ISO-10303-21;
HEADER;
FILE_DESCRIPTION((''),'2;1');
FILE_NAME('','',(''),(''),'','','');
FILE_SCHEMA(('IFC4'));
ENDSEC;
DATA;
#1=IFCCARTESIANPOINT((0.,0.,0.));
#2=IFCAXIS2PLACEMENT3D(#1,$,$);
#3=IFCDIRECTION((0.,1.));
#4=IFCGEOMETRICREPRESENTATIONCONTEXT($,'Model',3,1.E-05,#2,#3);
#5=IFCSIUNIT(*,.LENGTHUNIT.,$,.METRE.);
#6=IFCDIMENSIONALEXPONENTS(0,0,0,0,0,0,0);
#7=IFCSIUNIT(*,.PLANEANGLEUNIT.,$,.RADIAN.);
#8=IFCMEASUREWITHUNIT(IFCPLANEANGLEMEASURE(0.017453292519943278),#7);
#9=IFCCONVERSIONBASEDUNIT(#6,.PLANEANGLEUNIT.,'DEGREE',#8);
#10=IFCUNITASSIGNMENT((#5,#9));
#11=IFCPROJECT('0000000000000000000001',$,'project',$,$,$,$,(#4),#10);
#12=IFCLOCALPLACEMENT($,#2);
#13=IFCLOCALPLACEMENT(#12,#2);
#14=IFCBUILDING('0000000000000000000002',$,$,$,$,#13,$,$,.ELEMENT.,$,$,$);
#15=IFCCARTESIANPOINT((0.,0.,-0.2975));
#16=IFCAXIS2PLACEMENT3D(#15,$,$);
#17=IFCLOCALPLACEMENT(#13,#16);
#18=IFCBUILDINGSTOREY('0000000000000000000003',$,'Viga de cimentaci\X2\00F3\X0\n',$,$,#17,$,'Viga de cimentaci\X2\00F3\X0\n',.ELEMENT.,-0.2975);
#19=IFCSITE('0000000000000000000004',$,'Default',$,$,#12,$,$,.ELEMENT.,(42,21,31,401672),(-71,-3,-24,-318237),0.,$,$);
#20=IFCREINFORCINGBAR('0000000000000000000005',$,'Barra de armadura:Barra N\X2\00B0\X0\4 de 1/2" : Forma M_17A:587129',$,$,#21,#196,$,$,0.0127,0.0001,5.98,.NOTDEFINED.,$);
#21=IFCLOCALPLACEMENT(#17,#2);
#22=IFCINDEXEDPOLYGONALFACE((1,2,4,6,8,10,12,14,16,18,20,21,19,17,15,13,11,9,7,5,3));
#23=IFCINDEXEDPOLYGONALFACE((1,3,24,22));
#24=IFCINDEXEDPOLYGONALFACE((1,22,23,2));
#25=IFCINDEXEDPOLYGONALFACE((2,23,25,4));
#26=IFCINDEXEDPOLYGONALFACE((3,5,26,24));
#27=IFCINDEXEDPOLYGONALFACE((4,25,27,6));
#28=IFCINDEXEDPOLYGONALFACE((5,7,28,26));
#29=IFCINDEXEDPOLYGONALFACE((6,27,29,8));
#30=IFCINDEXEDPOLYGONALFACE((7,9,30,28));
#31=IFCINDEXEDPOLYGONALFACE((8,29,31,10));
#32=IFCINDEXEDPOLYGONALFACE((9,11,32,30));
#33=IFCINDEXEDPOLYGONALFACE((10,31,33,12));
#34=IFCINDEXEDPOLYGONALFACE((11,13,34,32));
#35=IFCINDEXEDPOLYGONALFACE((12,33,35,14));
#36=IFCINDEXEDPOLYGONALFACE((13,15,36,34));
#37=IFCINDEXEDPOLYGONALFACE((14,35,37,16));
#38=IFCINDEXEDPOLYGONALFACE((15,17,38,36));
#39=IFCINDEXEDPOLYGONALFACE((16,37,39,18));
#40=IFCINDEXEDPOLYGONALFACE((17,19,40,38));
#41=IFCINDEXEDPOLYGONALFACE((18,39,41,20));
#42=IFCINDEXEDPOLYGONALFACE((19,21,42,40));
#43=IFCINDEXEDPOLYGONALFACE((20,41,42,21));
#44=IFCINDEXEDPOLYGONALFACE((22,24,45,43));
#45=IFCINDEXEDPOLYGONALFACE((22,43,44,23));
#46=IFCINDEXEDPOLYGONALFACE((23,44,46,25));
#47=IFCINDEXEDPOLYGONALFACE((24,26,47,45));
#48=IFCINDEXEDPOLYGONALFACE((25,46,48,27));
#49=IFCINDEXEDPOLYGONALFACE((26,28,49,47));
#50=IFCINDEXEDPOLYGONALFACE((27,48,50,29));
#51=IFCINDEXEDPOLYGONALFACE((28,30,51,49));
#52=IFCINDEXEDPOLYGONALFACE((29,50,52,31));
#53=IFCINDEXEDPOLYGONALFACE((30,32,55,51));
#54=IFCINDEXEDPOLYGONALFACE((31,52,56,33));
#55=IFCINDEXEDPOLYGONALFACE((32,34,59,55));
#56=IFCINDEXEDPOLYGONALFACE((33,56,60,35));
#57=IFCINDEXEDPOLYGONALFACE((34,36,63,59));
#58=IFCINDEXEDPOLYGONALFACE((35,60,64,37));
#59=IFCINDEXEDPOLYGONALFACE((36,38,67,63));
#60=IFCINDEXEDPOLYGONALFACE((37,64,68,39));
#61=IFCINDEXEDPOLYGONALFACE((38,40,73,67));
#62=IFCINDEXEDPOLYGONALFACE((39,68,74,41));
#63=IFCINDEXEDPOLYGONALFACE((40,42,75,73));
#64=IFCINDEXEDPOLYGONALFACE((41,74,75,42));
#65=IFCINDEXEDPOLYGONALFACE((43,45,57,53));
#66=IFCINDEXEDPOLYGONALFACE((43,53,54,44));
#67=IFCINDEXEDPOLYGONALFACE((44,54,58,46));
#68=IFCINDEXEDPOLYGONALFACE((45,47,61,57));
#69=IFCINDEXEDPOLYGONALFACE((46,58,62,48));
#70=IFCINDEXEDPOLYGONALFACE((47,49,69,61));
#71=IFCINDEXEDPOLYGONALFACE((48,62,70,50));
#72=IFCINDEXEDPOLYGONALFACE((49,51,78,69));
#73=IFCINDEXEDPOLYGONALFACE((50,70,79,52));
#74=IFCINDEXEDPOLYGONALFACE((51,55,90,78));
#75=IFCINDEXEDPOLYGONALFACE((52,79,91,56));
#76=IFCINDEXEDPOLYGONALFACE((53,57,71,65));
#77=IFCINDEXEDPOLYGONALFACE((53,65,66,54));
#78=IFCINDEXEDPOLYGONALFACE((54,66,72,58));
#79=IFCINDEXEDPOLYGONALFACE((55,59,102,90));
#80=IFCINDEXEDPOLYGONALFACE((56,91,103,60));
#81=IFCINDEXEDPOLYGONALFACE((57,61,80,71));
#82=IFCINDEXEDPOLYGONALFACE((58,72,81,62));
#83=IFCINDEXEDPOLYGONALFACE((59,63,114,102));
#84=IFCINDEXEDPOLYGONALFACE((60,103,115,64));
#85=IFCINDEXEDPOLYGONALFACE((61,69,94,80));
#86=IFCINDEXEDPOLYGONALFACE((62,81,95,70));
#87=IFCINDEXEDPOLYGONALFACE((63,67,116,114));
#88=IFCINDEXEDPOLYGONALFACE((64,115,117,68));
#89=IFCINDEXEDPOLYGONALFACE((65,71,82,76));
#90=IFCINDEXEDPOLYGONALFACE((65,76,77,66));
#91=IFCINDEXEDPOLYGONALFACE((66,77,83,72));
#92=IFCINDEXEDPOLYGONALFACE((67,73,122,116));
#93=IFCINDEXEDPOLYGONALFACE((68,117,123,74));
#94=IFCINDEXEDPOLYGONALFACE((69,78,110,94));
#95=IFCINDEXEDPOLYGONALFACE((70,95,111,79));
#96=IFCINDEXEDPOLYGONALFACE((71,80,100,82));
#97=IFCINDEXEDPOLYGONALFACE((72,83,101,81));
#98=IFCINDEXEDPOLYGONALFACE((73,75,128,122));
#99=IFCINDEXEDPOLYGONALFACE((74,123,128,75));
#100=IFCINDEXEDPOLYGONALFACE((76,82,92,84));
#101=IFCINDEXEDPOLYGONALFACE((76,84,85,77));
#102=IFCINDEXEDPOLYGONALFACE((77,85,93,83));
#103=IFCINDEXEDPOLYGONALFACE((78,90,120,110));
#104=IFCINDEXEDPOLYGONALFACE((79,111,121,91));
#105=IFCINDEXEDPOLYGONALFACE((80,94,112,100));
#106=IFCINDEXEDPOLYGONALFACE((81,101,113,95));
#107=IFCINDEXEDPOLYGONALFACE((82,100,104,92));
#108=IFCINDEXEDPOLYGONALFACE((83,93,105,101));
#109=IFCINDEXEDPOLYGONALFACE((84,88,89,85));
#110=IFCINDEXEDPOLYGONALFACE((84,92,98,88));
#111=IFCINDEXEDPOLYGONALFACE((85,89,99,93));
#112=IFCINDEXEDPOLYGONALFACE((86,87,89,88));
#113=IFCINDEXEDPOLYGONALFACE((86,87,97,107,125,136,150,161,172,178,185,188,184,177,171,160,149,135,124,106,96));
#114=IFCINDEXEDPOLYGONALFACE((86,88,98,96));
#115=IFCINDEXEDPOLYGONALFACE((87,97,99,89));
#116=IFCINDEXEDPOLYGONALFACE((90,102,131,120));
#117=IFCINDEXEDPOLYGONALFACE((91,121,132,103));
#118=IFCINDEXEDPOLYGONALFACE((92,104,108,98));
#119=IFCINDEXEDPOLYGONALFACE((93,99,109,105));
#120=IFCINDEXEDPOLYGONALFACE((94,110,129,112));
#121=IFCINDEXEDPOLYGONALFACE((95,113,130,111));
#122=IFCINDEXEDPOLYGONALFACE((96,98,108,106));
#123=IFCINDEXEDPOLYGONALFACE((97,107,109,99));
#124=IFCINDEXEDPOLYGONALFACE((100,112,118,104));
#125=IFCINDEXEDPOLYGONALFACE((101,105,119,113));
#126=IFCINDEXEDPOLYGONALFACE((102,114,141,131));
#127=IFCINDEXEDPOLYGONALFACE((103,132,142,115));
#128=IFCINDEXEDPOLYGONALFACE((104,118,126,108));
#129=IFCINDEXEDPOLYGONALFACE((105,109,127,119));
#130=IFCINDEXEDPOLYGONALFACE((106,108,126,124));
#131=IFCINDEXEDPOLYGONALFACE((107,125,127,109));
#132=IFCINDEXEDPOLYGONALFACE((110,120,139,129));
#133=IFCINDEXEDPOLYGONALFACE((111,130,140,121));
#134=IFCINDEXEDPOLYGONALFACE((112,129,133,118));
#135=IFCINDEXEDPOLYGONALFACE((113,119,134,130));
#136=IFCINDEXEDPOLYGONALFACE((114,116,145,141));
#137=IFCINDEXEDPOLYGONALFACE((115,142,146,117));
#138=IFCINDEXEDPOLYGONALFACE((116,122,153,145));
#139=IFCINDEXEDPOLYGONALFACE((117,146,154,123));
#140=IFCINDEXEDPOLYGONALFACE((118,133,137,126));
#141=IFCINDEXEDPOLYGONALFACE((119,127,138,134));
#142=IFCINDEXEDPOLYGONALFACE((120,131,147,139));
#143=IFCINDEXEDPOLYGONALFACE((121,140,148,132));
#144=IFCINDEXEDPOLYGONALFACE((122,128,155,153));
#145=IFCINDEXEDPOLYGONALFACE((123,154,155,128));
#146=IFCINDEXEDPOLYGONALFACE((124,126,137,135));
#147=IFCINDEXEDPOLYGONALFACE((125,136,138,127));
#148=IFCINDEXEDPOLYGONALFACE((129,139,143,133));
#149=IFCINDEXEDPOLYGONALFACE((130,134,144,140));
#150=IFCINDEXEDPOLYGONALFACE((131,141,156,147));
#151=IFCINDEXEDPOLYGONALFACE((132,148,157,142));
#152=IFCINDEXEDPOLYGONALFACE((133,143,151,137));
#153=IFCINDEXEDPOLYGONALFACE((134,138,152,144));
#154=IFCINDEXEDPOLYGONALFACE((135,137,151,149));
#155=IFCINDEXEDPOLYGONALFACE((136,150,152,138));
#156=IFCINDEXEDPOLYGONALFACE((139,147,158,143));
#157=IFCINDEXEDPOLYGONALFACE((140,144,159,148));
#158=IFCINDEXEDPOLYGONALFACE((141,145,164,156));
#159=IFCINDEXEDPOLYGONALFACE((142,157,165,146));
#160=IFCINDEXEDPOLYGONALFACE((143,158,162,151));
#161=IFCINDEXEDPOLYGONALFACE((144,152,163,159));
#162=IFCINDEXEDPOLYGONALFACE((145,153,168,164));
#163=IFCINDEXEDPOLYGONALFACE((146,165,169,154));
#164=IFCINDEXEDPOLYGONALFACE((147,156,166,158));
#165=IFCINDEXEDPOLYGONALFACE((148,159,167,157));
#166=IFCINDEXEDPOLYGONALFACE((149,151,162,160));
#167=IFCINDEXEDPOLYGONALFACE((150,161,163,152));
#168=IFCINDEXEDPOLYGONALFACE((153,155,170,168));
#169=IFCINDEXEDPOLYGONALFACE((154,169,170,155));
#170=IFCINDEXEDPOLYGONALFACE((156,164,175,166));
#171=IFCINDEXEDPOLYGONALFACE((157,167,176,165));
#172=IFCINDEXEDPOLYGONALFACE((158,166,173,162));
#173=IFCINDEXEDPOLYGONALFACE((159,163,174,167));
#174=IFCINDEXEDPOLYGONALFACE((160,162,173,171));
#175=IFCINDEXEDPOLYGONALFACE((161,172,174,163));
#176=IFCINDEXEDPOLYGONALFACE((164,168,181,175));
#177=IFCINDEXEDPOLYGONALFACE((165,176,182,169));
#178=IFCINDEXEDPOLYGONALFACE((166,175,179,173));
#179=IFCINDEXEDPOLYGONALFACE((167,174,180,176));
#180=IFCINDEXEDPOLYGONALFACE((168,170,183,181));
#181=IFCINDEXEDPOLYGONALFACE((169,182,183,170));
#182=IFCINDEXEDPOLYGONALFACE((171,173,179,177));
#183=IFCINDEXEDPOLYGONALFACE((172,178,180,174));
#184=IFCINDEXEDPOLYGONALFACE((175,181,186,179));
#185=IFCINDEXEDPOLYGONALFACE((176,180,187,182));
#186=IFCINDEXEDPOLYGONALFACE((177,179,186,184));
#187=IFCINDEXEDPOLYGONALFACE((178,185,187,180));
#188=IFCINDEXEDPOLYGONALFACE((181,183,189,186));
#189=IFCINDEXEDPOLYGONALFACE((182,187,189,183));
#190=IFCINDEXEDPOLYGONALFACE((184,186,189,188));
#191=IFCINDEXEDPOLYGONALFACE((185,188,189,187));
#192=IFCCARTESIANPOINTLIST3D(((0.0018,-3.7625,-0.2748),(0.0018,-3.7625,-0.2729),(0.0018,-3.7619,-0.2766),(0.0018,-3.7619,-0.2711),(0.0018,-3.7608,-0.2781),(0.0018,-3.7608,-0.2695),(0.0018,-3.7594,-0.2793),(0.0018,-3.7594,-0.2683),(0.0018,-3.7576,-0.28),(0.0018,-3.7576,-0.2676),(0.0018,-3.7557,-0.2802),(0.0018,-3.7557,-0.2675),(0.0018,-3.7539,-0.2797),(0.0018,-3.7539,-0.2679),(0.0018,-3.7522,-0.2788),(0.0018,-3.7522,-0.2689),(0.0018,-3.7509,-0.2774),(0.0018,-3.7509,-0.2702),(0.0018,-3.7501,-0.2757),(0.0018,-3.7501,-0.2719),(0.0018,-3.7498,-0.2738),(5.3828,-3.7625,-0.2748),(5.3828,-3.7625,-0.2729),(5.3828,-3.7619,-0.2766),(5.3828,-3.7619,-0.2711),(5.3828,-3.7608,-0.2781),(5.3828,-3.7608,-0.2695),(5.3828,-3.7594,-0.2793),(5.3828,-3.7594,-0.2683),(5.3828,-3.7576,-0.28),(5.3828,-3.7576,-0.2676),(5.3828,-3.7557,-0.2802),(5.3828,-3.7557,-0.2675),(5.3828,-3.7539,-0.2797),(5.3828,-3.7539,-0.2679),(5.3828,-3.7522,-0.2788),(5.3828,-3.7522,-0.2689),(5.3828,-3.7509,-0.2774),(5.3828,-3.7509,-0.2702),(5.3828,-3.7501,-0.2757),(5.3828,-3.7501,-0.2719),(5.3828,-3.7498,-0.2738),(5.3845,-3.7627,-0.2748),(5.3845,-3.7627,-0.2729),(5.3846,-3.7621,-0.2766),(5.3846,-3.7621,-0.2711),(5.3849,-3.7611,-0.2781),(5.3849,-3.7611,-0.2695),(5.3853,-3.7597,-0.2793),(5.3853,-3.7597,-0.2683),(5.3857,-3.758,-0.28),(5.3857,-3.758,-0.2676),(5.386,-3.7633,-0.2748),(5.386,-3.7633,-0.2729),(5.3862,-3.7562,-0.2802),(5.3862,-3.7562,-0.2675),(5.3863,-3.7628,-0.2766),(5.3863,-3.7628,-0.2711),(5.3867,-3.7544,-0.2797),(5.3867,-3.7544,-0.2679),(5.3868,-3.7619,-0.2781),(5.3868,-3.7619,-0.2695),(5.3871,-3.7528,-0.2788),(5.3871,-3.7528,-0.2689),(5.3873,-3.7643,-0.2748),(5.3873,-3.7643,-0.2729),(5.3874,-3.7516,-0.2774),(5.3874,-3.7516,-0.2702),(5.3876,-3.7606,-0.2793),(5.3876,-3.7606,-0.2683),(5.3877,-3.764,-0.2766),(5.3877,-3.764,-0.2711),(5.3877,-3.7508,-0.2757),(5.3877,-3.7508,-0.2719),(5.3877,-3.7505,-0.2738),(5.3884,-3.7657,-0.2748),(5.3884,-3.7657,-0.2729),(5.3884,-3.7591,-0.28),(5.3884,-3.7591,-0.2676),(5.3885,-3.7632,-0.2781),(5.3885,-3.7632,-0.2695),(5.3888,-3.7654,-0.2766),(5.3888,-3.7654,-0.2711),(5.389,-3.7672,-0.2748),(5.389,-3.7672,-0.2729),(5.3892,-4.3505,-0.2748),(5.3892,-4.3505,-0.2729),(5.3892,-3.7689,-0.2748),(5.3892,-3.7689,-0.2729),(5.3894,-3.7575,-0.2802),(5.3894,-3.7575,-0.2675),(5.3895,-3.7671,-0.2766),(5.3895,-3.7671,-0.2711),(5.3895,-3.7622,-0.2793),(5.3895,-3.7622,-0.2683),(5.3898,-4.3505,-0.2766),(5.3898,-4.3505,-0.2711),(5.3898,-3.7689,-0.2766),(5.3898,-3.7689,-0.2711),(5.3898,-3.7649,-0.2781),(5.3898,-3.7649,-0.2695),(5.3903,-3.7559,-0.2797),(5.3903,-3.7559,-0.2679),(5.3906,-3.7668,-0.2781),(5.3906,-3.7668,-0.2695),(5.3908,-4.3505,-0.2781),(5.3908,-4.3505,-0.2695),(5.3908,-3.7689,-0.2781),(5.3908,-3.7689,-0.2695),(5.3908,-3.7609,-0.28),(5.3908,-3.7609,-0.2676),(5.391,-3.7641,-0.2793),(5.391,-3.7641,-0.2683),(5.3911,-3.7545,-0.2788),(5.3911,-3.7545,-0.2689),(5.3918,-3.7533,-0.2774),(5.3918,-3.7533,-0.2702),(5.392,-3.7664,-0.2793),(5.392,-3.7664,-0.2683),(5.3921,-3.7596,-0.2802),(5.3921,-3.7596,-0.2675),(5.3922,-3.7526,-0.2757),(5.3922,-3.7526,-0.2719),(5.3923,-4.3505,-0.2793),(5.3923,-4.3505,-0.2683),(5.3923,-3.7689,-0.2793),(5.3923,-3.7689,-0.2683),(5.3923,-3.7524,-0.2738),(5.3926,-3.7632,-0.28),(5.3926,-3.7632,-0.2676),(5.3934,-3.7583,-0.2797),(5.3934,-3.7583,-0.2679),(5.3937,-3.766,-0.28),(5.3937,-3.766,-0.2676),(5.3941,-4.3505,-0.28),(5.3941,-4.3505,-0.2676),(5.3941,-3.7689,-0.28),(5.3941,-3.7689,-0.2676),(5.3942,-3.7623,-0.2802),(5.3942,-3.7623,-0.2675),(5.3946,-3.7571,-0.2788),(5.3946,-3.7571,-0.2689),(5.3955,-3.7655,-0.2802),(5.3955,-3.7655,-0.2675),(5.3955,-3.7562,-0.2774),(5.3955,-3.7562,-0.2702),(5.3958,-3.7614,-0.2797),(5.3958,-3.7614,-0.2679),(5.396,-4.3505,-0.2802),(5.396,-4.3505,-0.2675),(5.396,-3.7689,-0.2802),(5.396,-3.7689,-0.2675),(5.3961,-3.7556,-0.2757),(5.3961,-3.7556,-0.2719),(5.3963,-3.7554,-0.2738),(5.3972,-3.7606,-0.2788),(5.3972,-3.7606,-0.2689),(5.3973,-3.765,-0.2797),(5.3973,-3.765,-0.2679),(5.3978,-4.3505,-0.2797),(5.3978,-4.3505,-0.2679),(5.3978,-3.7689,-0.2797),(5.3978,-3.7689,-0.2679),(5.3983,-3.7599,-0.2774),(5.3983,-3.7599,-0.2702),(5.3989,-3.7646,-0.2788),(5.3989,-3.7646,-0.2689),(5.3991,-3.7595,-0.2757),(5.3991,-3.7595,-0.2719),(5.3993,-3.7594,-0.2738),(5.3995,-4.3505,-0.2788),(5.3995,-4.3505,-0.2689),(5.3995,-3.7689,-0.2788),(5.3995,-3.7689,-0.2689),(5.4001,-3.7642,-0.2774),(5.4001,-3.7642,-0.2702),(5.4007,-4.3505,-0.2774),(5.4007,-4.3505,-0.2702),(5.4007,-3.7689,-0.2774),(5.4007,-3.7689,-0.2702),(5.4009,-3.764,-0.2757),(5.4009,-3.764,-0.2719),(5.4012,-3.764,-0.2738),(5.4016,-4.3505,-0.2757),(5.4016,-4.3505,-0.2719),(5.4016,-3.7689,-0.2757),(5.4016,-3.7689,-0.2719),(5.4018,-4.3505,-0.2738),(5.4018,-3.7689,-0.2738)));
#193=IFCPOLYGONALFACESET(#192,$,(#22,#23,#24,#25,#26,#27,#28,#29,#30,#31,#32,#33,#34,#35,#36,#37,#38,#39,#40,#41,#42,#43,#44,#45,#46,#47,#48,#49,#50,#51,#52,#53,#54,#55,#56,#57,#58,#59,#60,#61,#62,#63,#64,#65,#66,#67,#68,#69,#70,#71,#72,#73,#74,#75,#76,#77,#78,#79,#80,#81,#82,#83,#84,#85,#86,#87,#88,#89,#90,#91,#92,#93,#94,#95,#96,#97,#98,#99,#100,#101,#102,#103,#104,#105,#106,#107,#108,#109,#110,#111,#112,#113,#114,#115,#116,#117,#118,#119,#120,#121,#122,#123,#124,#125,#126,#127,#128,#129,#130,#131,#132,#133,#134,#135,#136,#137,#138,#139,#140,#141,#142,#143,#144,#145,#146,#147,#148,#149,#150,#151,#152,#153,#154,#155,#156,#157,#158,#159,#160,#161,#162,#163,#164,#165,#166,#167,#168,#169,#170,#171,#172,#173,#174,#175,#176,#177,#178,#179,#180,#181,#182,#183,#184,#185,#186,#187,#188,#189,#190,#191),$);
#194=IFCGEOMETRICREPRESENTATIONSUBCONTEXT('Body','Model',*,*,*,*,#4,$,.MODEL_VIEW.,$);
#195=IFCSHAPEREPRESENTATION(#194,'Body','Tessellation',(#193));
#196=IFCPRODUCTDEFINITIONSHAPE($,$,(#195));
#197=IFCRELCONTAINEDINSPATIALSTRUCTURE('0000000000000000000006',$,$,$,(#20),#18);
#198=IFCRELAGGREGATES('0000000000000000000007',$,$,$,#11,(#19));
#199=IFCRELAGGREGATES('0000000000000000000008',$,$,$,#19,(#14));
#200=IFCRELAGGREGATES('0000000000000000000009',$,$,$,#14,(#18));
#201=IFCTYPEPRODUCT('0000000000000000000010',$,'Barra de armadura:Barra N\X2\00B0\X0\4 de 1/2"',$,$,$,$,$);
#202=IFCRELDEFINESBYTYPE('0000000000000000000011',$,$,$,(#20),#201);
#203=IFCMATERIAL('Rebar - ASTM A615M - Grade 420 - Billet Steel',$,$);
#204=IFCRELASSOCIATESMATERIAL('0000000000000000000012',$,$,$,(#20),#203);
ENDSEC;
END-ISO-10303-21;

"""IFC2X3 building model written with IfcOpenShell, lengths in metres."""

from ifc_helpers import new_model, entity, si_unit, converted_unit, direction, frame, origin, place, context, subcontext, project, spatial, material, type_object, element, save


model = new_model("IFC2X3")

# Units and contexts
model_context = context("Model", 3, precision=1e-05, world=origin(), true_north=direction((0.0, 1.0)))
body_context = subcontext(model_context, "Body", "Model", "MODEL_VIEW")
ifc_project = project(units=[si_unit("LENGTHUNIT", "METRE"), converted_unit("PLANEANGLEUNIT", "DEGREE", entity("IfcPlaneAngleMeasure", 0.017453292519943278), si_unit("PLANEANGLEUNIT", "RADIAN"), dimensions=[0, 0, 0, 0, 0, 0, 0])], contexts=[model_context])

# Site, building, storey
site_placement = place(None, origin())
site = spatial("IfcSite", under=ifc_project, at=site_placement, Name="Default", CompositionType="ELEMENT", RefLatitude=(42, 21, 31, 401672), RefLongitude=(-71, -3, -24, -318237), RefElevation=0.0)
building_placement = place(site_placement, origin())
building = spatial("IfcBuilding", under=site, at=building_placement, CompositionType="ELEMENT")
storey_placement = place(building_placement, frame((0.0, 0.0, -0.2975)))
storey = spatial("IfcBuildingStorey", under=building, at=storey_placement, Name="Viga de cimentación", LongName="Viga de cimentación", CompositionType="ELEMENT", Elevation=-0.2975)

# Reinforcing bar
ifc_material = material(Name="Rebar - ASTM A615M - Grade 420 - Billet Steel")
type_product_1 = type_object("IfcTypeProduct", Name="Barra de armadura:Barra N°4 de 1/2\"")
reinforcing_bar_1_placement = place(storey_placement, origin())
element("IfcReinforcingBar", 1, at=reinforcing_bar_1_placement, inside=storey, type_object=type_product_1, material=ifc_material, Name="Barra de armadura:Barra N°4 de 1/2\" : Forma M_17A:587129", BarLength=5.98, BarRole="NOTDEFINED", CrossSectionArea=0.0001, NominalDiameter=0.0127, context=body_context, shape_type="AdvancedSweptSolid", body=[
    entity("IfcSweptDiskSolid", entity("IfcCompositeCurve", [entity("IfcCompositeCurveSegment", "CONTINUOUS", True, entity("IfcPolyline", [entity("IfcCartesianPoint", [5.3955, -4.3505, -0.2738]), entity("IfcCartesianPoint", [5.3955, -3.7689, -0.2738])])), entity("IfcCompositeCurveSegment", "CONTINUOUS", True, entity("IfcTrimmedCurve", entity("IfcCircle", entity("IfcAxis2Placement3D", entity("IfcCartesianPoint", [5.3828, -3.7689, -0.2738]), entity("IfcDirection", [0.0, 0.0, 1.0]), entity("IfcDirection", [0.0, 1.0, 0.0])), 0.0127), [entity("IfcParameterValue", 270.0)], [entity("IfcParameterValue", 360.0)], True, "PARAMETER")), entity("IfcCompositeCurveSegment", "CONTINUOUS", True, entity("IfcPolyline", [entity("IfcCartesianPoint", [5.3828, -3.7562, -0.2738]), entity("IfcCartesianPoint", [0.0018, -3.7562, -0.2738])]))], False), 0.0063, None, 0.0, 92.0),
])

save(model, "model.ifc")
